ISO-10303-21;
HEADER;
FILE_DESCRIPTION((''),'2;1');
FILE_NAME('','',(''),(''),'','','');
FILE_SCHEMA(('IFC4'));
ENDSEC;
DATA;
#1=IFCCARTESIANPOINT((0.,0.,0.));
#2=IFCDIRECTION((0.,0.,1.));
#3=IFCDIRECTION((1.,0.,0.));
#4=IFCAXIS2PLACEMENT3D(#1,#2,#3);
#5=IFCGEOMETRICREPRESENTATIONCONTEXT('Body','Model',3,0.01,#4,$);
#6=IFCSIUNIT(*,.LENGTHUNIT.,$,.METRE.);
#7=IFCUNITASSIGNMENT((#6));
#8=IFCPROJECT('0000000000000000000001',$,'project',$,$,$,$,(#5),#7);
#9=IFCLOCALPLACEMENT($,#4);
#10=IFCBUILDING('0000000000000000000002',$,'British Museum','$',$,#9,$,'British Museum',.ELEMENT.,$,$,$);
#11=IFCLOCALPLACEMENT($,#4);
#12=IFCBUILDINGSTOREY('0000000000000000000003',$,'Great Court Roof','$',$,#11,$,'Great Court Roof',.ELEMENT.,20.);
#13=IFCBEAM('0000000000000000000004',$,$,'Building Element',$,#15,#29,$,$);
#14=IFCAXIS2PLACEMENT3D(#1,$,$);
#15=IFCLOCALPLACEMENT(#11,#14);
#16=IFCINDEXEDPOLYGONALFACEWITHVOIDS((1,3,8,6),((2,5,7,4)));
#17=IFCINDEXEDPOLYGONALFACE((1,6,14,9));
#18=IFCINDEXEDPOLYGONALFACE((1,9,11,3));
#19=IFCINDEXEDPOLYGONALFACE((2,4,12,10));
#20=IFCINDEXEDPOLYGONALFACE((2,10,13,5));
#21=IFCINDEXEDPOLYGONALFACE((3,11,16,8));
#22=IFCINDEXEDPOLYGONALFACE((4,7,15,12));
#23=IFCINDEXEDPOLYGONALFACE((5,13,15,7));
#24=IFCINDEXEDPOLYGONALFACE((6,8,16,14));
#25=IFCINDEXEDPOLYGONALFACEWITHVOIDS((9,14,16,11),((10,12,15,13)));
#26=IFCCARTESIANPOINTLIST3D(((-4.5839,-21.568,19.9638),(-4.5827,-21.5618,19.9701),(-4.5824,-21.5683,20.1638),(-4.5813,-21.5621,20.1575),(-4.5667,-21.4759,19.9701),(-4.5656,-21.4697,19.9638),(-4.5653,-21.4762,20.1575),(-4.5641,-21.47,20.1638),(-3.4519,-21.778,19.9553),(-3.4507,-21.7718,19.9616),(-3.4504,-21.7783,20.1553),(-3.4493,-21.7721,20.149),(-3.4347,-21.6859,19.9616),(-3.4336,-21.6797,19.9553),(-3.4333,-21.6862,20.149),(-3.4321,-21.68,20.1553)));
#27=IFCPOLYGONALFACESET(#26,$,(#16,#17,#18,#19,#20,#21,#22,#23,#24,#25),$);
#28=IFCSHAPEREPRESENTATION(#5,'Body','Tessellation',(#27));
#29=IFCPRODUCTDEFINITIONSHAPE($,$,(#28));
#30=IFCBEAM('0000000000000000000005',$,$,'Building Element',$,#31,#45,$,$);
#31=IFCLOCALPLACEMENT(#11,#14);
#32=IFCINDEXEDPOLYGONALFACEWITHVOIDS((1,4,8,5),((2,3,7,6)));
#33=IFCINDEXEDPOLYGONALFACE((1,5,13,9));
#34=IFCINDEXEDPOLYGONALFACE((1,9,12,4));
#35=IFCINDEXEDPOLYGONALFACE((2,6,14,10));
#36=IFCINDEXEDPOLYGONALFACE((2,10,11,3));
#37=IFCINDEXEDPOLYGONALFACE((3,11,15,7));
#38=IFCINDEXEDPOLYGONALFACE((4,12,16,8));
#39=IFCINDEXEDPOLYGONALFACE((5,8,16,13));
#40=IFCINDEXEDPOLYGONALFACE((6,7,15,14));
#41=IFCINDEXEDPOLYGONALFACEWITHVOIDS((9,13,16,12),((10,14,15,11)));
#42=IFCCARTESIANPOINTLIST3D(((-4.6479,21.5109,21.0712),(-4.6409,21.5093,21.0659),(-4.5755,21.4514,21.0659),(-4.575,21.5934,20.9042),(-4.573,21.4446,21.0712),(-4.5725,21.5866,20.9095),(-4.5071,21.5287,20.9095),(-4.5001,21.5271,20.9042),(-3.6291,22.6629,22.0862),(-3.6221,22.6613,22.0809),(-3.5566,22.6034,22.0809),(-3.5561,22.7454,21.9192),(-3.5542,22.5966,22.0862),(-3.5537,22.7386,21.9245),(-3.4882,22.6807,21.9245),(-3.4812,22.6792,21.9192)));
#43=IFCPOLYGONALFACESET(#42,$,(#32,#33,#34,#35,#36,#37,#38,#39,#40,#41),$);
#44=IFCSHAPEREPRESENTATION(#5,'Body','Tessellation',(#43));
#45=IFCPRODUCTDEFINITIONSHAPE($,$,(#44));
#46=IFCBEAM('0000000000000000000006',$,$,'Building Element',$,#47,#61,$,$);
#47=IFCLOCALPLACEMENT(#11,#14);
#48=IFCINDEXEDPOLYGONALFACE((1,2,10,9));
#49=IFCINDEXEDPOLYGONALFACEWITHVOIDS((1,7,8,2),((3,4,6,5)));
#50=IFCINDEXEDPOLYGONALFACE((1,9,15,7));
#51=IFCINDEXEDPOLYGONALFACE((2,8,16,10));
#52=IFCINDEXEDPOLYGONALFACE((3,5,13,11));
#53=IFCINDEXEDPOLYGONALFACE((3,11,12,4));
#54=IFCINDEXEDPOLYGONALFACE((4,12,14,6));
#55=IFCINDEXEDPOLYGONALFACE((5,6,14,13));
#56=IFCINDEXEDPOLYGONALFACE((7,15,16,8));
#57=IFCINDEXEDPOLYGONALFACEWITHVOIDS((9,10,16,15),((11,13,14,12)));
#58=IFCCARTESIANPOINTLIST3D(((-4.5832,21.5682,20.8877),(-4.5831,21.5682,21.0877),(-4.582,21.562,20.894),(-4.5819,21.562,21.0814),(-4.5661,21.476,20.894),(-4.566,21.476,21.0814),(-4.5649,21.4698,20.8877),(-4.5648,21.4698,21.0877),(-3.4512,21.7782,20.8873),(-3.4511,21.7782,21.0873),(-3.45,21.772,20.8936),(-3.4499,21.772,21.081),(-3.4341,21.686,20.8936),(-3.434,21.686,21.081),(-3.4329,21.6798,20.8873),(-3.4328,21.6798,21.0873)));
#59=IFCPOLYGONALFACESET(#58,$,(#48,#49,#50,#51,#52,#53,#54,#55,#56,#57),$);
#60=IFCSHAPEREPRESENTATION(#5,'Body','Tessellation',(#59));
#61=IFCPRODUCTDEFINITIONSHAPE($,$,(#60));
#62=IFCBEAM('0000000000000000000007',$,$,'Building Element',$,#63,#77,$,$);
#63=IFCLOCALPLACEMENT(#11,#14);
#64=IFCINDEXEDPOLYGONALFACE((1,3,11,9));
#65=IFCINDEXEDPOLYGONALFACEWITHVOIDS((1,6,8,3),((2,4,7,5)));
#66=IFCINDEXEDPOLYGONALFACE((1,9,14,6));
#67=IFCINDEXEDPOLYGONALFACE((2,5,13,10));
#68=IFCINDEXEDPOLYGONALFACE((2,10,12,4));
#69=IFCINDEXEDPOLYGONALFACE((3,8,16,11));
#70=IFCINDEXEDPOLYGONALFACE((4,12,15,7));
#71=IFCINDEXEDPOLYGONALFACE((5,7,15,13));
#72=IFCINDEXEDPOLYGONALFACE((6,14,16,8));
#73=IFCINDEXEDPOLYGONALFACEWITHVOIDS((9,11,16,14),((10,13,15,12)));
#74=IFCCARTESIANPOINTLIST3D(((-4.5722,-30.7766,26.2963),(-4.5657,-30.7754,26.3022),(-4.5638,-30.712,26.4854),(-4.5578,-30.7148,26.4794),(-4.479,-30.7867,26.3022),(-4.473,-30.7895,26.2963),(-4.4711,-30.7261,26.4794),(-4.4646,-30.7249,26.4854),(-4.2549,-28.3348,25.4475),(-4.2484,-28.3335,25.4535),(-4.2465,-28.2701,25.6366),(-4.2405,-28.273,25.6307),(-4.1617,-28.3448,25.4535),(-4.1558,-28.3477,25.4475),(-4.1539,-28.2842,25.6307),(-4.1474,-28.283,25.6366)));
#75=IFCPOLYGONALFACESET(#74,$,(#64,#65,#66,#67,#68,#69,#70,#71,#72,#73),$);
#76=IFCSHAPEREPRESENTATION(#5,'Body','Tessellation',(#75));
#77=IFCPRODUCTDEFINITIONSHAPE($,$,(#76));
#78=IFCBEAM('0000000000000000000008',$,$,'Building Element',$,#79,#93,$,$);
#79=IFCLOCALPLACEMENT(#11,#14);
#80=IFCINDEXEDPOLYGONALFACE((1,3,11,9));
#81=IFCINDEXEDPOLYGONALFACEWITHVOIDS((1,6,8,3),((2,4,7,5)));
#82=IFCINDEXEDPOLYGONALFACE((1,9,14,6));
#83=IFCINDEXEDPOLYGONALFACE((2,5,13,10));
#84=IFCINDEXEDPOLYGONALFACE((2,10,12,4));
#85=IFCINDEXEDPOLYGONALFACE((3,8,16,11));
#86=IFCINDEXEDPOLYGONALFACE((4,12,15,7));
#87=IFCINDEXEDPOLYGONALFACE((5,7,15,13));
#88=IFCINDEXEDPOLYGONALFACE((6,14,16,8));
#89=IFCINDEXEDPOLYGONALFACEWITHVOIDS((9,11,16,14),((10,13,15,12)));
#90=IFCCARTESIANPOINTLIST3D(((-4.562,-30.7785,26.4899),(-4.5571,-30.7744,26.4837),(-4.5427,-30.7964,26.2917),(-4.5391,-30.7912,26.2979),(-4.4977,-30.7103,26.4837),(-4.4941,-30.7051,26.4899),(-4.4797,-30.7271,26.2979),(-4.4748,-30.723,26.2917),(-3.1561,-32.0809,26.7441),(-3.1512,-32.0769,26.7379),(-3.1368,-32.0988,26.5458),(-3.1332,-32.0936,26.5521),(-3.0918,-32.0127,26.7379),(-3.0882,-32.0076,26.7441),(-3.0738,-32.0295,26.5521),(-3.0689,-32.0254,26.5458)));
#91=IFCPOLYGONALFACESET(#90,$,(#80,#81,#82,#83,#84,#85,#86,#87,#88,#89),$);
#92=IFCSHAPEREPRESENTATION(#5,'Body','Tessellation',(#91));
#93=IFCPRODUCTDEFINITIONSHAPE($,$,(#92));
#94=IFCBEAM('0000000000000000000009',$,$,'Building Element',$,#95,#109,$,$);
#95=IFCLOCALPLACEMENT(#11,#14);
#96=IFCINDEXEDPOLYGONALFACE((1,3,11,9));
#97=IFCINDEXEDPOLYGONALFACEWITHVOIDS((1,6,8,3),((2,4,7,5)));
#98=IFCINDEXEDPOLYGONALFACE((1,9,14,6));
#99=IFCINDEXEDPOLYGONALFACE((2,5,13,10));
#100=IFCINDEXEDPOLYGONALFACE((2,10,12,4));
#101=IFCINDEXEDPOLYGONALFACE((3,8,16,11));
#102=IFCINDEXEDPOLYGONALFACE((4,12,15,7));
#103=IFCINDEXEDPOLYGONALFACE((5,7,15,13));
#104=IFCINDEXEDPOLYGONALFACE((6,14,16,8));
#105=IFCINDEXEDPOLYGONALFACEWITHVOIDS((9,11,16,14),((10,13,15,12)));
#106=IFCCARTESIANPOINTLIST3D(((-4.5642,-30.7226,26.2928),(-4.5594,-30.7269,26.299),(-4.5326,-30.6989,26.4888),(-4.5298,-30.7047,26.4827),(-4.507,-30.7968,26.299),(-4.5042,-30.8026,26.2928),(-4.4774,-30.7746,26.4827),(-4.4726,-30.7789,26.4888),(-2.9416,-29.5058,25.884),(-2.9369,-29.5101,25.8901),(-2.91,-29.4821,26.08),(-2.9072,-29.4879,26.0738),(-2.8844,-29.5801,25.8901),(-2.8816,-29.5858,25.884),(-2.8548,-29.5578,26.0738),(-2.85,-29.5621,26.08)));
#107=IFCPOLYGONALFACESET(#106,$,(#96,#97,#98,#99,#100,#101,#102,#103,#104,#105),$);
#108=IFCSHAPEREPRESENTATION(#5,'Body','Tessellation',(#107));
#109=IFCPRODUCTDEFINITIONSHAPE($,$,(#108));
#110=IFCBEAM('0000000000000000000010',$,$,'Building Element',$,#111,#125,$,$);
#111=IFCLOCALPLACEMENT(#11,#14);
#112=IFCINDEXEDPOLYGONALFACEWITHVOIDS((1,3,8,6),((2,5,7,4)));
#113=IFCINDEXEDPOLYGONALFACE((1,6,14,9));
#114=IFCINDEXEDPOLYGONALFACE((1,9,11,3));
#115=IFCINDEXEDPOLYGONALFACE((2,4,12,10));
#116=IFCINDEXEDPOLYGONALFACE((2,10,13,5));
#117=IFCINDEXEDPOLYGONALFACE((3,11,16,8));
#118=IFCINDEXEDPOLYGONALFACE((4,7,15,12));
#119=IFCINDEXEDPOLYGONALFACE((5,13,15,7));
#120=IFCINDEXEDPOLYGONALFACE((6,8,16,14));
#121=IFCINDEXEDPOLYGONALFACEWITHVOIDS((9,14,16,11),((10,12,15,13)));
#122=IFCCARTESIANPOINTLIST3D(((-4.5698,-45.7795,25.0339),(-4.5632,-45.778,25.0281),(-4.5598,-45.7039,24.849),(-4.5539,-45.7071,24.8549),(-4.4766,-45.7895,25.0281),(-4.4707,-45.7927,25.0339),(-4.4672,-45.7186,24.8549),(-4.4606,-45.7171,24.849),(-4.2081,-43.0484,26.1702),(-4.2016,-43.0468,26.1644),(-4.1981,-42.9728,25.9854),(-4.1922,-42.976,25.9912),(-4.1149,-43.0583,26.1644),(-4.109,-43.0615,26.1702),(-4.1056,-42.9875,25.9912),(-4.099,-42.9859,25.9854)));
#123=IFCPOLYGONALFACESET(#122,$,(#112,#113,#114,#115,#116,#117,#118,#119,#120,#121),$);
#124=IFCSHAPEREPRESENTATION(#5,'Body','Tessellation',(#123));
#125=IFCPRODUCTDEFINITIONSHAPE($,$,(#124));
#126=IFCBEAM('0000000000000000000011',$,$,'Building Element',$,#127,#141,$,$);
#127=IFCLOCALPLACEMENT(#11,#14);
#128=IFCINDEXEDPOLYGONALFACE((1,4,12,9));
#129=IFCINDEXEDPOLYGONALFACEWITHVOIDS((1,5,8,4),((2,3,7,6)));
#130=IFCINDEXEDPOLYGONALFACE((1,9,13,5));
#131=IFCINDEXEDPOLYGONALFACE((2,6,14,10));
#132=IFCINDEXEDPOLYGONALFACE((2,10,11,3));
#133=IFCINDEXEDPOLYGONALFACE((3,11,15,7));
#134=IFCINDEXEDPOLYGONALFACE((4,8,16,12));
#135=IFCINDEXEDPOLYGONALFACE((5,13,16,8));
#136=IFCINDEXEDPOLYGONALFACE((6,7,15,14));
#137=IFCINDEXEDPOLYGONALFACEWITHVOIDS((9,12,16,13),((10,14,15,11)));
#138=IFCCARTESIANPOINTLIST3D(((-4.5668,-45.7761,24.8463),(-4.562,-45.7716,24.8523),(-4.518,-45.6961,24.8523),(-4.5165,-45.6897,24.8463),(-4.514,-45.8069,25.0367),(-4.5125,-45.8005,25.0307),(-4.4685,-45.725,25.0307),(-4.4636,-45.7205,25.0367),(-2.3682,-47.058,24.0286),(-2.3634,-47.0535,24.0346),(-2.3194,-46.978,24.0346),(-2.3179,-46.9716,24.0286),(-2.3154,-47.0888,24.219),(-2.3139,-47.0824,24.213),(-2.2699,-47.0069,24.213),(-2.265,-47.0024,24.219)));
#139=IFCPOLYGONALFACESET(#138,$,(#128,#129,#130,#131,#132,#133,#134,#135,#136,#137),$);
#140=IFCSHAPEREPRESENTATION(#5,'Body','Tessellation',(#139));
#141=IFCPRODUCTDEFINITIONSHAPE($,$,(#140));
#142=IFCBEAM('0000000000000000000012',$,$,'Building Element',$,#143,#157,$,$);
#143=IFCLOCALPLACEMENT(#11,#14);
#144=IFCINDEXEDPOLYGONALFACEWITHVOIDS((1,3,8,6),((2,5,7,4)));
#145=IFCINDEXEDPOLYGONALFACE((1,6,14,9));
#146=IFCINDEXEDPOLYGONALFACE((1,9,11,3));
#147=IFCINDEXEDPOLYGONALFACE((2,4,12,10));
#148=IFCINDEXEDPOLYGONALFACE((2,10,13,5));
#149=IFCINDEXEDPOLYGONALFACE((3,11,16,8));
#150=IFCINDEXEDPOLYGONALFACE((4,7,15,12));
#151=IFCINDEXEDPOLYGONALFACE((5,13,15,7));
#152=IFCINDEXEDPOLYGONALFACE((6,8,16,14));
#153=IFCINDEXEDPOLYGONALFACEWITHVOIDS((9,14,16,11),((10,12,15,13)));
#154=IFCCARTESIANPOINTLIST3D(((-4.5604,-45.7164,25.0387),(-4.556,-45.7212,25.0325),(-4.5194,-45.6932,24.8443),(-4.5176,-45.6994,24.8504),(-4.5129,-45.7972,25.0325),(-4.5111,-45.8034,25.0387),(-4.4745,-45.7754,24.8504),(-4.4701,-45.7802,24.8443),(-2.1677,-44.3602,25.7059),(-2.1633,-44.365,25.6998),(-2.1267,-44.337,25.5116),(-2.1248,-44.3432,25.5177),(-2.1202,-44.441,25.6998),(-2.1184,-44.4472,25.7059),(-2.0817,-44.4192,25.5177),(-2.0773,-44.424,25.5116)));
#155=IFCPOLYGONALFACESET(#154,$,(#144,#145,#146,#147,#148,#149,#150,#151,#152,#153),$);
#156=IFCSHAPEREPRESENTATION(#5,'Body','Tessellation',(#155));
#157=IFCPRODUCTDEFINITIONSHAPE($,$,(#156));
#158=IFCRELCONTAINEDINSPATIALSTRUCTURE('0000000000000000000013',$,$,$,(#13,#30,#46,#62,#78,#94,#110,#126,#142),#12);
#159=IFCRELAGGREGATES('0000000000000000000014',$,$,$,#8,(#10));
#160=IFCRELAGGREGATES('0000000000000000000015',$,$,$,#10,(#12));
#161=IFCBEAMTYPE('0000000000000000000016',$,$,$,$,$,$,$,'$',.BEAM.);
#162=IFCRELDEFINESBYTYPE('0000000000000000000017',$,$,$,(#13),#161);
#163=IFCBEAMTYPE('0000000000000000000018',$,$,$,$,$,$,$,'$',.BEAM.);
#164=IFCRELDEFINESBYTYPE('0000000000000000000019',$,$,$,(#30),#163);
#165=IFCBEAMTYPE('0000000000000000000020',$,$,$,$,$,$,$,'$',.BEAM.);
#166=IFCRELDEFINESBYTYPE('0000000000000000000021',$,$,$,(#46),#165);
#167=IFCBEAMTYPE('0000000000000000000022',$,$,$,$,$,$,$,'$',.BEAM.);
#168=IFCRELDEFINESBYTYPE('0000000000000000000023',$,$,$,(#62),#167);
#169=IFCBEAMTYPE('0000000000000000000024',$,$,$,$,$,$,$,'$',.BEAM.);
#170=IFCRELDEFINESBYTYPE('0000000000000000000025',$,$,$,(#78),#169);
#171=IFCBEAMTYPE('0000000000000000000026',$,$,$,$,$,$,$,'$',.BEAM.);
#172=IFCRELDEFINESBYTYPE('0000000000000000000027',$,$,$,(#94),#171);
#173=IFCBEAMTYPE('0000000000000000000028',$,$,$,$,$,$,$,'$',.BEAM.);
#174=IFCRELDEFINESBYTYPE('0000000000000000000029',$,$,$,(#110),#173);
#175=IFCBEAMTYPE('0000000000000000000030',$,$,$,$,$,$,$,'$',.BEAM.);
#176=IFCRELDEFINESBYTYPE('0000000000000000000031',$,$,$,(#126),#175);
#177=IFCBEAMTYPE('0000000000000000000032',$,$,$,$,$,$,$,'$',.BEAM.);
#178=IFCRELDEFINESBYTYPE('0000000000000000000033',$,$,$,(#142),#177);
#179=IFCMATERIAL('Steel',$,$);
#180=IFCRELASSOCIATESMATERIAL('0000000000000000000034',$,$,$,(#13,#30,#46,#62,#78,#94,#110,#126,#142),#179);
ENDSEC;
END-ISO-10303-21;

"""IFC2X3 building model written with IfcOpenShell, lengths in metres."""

from ifc_helpers import new_model, si_unit, frame, origin_with_axes, origin_2d, place, context, project, spatial, hollow_rectangle, extrude, material, type_object, element, save


model = new_model("IFC2X3")

# Units and contexts
model_context = context("Model", 3, precision=0.01, world=origin_with_axes(), identifier="Body")
ifc_project = project(units=[si_unit("LENGTHUNIT", "METRE")], contexts=[model_context])

# Building, storey
building_placement = place(None, origin_with_axes())
building = spatial("IfcBuilding", under=ifc_project, at=building_placement, Name="British Museum", Description="$", LongName="British Museum", CompositionType="ELEMENT")
storey_placement = place(None, origin_with_axes())
storey = spatial("IfcBuildingStorey", under=building, at=storey_placement, Name="Great Court Roof", Description="$", LongName="Great Court Roof", CompositionType="ELEMENT", Elevation=20.0)

# Beams
ifc_material = material(Name="Steel")
beam_type_1 = type_object("IfcBeamType", ElementType="$", PredefinedType="BEAM")
beam_1_placement = place(None, origin_with_axes())
element("IfcBeam", 1, at=beam_1_placement, inside=storey, type_object=beam_type_1, material=ifc_material, Description="Building Element", context=model_context, shape_type="SweptSolid", body=[
    extrude(hollow_rectangle(XDim=0.1, YDim=0.2, WallThickness=0.0063, InnerFilletRadius=-0.0063, OuterFilletRadius=0.0, at=origin_2d()), frame((-4.574, -21.519, 20.0638), z_axis=(0.983197, -0.182396, -0.007435), x_axis=(0.182401, 0.983224, 0.0)), (0.0, 0.0, 1.0), 1.1513),
])
beam_type_2 = type_object("IfcBeamType", ElementType="$", PredefinedType="BEAM")
beam_2_placement = place(None, origin_with_axes())
element("IfcBeam", 2, at=beam_2_placement, inside=storey, type_object=beam_type_2, material=ifc_material, Description="Building Element", context=model_context, shape_type="SweptSolid", body=[
    extrude(hollow_rectangle(XDim=0.1, YDim=0.2, WallThickness=0.0063, InnerFilletRadius=-0.0063, OuterFilletRadius=0.0, at=origin_2d()), frame((-4.574, 21.519, 20.9877), z_axis=(0.55291, 0.6252, 0.550831), x_axis=(-0.749087, 0.662472, 0.0)), (0.0, 0.0, 1.0), 1.8427),
])
beam_type_3 = type_object("IfcBeamType", ElementType="$", PredefinedType="BEAM")
beam_3_placement = place(None, origin_with_axes())
element("IfcBeam", 3, at=beam_3_placement, inside=storey, type_object=beam_type_3, material=ifc_material, Description="Building Element", context=model_context, shape_type="SweptSolid", body=[
    extrude(hollow_rectangle(XDim=0.1, YDim=0.2, WallThickness=0.0063, InnerFilletRadius=-0.0063, OuterFilletRadius=0.0, at=origin_2d()), frame((-4.574, 21.519, 20.9877), z_axis=(0.983224, 0.182401, -0.000354), x_axis=(-0.182401, 0.983224, 0.0)), (0.0, 0.0, 1.0), 1.1513),
])
beam_type_4 = type_object("IfcBeamType", ElementType="$", PredefinedType="BEAM")
beam_4_placement = place(None, origin_with_axes())
element("IfcBeam", 4, at=beam_4_placement, inside=storey, type_object=beam_type_4, material=ifc_material, Description="Building Element", context=model_context, shape_type="SweptSolid", body=[
    extrude(hollow_rectangle(XDim=0.1, YDim=0.2, WallThickness=0.0063, InnerFilletRadius=-0.0063, OuterFilletRadius=0.0, at=origin_2d()), frame((-4.5184, -30.7508, 26.3908), z_axis=(0.121807, 0.937536, -0.325868), x_axis=(-0.991666, 0.128839, 0.0)), (0.0, 0.0, 1.0), 2.6045),
])
beam_type_5 = type_object("IfcBeamType", ElementType="$", PredefinedType="BEAM")
beam_5_placement = place(None, origin_with_axes())
element("IfcBeam", 5, at=beam_5_placement, inside=storey, type_object=beam_type_5, material=ifc_material, Description="Building Element", context=model_context, shape_type="SweptSolid", body=[
    extrude(hollow_rectangle(XDim=0.1, YDim=0.2, WallThickness=0.0063, InnerFilletRadius=-0.0063, OuterFilletRadius=0.0, at=origin_2d()), frame((-4.5184, -30.7508, 26.3908), z_axis=(0.72722, -0.673695, 0.131473), x_axis=(0.679594, 0.733588, 0.0)), (0.0, 0.0, 1.0), 1.9333),
])
beam_type_6 = type_object("IfcBeamType", ElementType="$", PredefinedType="BEAM")
beam_6_placement = place(None, origin_with_axes())
element("IfcBeam", 6, at=beam_6_placement, inside=storey, type_object=beam_type_6, material=ifc_material, Description="Building Element", context=model_context, shape_type="SweptSolid", body=[
    extrude(hollow_rectangle(XDim=0.1, YDim=0.2, WallThickness=0.0063, InnerFilletRadius=-0.0063, OuterFilletRadius=0.0, at=origin_2d()), frame((-4.5184, -30.7508, 26.3908), z_axis=(0.784262, 0.588121, -0.197605), x_axis=(-0.599951, 0.800037, 0.0)), (0.0, 0.0, 1.0), 2.0689),
])
beam_type_7 = type_object("IfcBeamType", ElementType="$", PredefinedType="BEAM")
beam_7_placement = place(None, origin_with_axes())
element("IfcBeam", 7, at=beam_7_placement, inside=storey, type_object=beam_type_7, material=ifc_material, Description="Building Element", context=model_context, shape_type="SweptSolid", body=[
    extrude(hollow_rectangle(XDim=0.1, YDim=0.2, WallThickness=0.0063, InnerFilletRadius=-0.0063, OuterFilletRadius=0.0, at=origin_2d()), frame((-4.5152, -45.7483, 24.9415), z_axis=(0.121353, 0.916452, 0.3813), x_axis=(-0.991347, 0.131271, 0.0)), (0.0, 0.0, 1.0), 2.9801),
])
beam_type_8 = type_object("IfcBeamType", ElementType="$", PredefinedType="BEAM")
beam_8_placement = place(None, origin_with_axes())
element("IfcBeam", 8, at=beam_8_placement, inside=storey, type_object=beam_type_8, material=ifc_material, Description="Building Element", context=model_context, shape_type="SweptSolid", body=[
    extrude(hollow_rectangle(XDim=0.1, YDim=0.2, WallThickness=0.0063, InnerFilletRadius=-0.0063, OuterFilletRadius=0.0, at=origin_2d()), frame((-4.5152, -45.7483, 24.9415), z_axis=(0.822479, -0.47955, -0.305877), x_axis=(0.503691, 0.863884, 0.0)), (0.0, 0.0, 1.0), 2.6731),
])
beam_type_9 = type_object("IfcBeamType", ElementType="$", PredefinedType="BEAM")
beam_9_placement = place(None, origin_with_axes())
element("IfcBeam", 9, at=beam_9_placement, inside=storey, type_object=beam_type_9, material=ifc_material, Description="Building Element", context=model_context, shape_type="SweptSolid", body=[
    extrude(hollow_rectangle(XDim=0.1, YDim=0.2, WallThickness=0.0063, InnerFilletRadius=-0.0063, OuterFilletRadius=0.0, at=origin_2d()), frame((-4.5152, -45.7483, 24.9415), z_axis=(0.845445, 0.479203, 0.235769), x_axis=(-0.493104, 0.869971, 0.0)), (0.0, 0.0, 1.0), 2.8301),
])

save(model, "model.ifc")
